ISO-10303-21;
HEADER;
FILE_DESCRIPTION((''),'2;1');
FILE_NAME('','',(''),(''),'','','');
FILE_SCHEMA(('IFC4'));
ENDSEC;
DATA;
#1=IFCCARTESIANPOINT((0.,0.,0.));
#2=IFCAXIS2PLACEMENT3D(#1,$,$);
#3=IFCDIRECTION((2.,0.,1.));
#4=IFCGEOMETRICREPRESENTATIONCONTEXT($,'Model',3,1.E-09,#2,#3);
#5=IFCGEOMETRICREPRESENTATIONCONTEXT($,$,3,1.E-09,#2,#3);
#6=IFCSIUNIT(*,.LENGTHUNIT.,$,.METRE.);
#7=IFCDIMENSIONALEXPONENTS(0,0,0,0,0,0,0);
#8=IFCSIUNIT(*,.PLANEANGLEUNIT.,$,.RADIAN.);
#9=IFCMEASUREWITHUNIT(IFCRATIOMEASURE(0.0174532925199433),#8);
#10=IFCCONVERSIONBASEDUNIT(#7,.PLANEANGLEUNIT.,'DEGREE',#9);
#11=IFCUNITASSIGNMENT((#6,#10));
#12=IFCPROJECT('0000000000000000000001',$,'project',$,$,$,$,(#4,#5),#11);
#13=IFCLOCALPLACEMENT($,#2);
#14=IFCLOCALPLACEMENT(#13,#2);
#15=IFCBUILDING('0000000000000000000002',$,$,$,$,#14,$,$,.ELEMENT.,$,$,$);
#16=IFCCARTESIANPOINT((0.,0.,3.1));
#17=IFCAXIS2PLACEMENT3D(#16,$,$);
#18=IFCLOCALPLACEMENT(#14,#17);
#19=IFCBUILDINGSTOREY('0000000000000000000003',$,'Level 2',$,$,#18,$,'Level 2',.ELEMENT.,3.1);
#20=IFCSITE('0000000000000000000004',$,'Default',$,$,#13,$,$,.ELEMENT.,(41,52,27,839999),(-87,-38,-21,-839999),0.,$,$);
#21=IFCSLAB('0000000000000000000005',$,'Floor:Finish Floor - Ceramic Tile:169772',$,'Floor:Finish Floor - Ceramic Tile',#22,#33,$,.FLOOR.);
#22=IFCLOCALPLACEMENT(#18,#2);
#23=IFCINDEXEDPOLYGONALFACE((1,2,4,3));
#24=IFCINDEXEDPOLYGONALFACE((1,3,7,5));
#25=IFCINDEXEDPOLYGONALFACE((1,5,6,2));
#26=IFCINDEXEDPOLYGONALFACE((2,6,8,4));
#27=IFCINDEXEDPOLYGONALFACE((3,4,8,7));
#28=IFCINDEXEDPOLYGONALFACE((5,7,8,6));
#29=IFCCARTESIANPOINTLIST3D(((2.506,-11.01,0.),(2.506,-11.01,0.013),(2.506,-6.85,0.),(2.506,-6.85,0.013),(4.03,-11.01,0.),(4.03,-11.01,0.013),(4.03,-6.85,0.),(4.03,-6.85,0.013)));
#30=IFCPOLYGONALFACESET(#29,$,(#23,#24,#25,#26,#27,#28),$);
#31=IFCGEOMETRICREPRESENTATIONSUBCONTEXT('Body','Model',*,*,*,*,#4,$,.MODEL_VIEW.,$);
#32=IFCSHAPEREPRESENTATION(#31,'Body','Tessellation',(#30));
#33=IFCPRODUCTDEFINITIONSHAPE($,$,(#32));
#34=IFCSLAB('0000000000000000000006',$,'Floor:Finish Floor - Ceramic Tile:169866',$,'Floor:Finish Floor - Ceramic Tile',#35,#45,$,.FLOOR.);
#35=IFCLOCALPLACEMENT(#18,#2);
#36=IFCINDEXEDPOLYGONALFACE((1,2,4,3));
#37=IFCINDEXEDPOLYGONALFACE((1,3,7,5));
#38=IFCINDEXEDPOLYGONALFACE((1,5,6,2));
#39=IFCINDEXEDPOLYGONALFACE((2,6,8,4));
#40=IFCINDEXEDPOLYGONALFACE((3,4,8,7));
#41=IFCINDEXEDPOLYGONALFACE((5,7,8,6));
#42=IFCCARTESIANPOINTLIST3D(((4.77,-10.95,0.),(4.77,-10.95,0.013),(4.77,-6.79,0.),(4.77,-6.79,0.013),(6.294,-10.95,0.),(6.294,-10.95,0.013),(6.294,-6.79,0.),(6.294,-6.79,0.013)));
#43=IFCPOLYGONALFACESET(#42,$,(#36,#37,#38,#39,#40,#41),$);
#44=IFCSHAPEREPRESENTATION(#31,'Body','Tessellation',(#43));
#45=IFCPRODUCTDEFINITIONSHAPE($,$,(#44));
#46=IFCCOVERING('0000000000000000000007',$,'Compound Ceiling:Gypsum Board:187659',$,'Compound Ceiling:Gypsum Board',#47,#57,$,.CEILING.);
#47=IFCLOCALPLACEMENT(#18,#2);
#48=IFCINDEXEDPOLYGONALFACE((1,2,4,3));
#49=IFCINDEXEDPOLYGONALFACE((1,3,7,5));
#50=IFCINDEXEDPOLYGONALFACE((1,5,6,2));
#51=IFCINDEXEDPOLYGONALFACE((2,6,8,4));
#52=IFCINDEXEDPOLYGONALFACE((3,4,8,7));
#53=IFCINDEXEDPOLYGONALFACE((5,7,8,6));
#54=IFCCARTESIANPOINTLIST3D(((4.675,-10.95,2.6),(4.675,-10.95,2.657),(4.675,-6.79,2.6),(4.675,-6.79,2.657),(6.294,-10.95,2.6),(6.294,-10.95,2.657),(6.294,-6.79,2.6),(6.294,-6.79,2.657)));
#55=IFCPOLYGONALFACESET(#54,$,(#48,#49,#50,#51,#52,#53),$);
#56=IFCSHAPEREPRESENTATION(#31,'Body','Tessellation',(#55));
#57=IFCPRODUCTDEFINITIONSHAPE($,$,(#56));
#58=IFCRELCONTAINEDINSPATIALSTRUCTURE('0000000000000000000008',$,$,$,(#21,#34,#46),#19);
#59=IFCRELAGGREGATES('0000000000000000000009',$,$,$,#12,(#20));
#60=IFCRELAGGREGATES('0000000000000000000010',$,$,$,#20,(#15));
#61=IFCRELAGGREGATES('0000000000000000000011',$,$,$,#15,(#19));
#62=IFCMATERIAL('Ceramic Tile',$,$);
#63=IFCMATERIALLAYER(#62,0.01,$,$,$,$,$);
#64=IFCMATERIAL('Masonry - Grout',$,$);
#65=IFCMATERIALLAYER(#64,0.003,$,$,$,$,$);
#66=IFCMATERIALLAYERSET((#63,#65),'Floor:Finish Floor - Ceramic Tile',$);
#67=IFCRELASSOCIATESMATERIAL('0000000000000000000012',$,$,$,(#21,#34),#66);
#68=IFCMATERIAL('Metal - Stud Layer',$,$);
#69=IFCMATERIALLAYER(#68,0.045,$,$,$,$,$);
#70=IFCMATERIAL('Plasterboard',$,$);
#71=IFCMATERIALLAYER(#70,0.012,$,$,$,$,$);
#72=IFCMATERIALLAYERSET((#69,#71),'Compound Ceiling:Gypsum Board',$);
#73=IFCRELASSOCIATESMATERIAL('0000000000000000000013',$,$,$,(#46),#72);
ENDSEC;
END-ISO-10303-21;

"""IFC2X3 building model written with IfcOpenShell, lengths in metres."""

from ifc_helpers import new_model, entity, si_unit, converted_unit, direction, frame, frame_2d, origin, place, context, subcontext, project, spatial, rectangle, extrude, material, layer, layer_set, layer_usage, element, save


model = new_model("IFC2X3")

# Units and contexts
model_context = context("Model", 3, precision=1e-09, world=origin(), true_north=direction((2.0, 0.0, 1.0)))
context_of_model = context(None, 3, precision=1e-09, world=origin(), true_north=direction((2.0, 0.0, 1.0)))
body_context = subcontext(model_context, "Body", "Model", "MODEL_VIEW")
ifc_project = project(units=[si_unit("LENGTHUNIT", "METRE"), converted_unit("PLANEANGLEUNIT", "DEGREE", entity("IfcRatioMeasure", 0.0174532925199433), si_unit("PLANEANGLEUNIT", "RADIAN"), dimensions=[0, 0, 0, 0, 0, 0, 0])], contexts=[model_context, context_of_model])

# Site, building, storey
site_placement = place(None, origin())
site = spatial("IfcSite", under=ifc_project, at=site_placement, Name="Default", CompositionType="ELEMENT", RefLatitude=(41, 52, 27, 839999), RefLongitude=(-87, -38, -21, -839999), RefElevation=0.0)
building_placement = place(site_placement, origin())
building = spatial("IfcBuilding", under=site, at=building_placement, CompositionType="ELEMENT")
storey_placement = place(building_placement, frame((0.0, 0.0, 3.1)))
storey = spatial("IfcBuildingStorey", under=building, at=storey_placement, Name="Level 2", LongName="Level 2", CompositionType="ELEMENT", Elevation=3.1)

# Slabs
ifc_material_1 = material(Name="Ceramic Tile")
ifc_layer_1 = layer(ifc_material_1, 0.01)
ifc_material_2 = material(Name="Masonry - Grout")
ifc_layer_2 = layer(ifc_material_2, 0.003)
ifc_layer_set_1 = layer_set([ifc_layer_1, ifc_layer_2], Name="Floor:Finish Floor - Ceramic Tile")
ifc_layer_usage_1 = layer_usage(ifc_layer_set_1, "AXIS3", "POSITIVE", 0.0)
slab_1_placement = place(storey_placement, origin())
element("IfcSlab", 1, at=slab_1_placement, inside=storey, material=ifc_layer_usage_1, Name="Floor:Finish Floor - Ceramic Tile:169772", ObjectType="Floor:Finish Floor - Ceramic Tile", PredefinedType="FLOOR", context=body_context, shape_type="SweptSolid", body=[
    extrude(rectangle(XDim=4.16, YDim=1.524, at=frame_2d((0.0, 0.0), x_axis=(1.0, 0.0))), frame((3.268, -8.93, 0.013), z_axis=(0.0, 0.0, -1.0), x_axis=(0.0, 1.0, 0.0)), (0.0, 0.0, 1.0), 0.013),
])
ifc_layer_usage_2 = layer_usage(ifc_layer_set_1, "AXIS3", "POSITIVE", 0.0)
slab_2_placement = place(storey_placement, origin())
element("IfcSlab", 2, at=slab_2_placement, inside=storey, material=ifc_layer_usage_2, Name="Floor:Finish Floor - Ceramic Tile:169866", ObjectType="Floor:Finish Floor - Ceramic Tile", PredefinedType="FLOOR", context=body_context, shape_type="SweptSolid", body=[
    extrude(rectangle(XDim=4.16, YDim=1.524, at=frame_2d((0.0, 0.0), x_axis=(1.0, 0.0))), frame((5.532, -8.87, 0.013), z_axis=(0.0, 0.0, -1.0), x_axis=(0.0, 1.0, 0.0)), (0.0, 0.0, 1.0), 0.013),
])

# Shared definitions
ifc_material_3 = material(Name="Metal - Stud Layer")
ifc_material_4 = material(Name="Plasterboard")

# Shared definitions
ifc_layer_3 = layer(ifc_material_3, 0.045)
ifc_layer_4 = layer(ifc_material_4, 0.012)
ifc_layer_set_2 = layer_set([ifc_layer_3, ifc_layer_4], Name="Compound Ceiling:Gypsum Board")

# Covering
ifc_layer_usage_3 = layer_usage(ifc_layer_set_2, "AXIS3", "NEGATIVE", 0.0)
covering_1_placement = place(storey_placement, origin())
element("IfcCovering", 3, at=covering_1_placement, inside=storey, material=ifc_layer_usage_3, Name="Compound Ceiling:Gypsum Board:187659", ObjectType="Compound Ceiling:Gypsum Board", PredefinedType="CEILING", context=body_context, shape_type="SweptSolid", body=[
    extrude(rectangle(XDim=1.619, YDim=4.16, at=frame_2d((0.0, 0.0), x_axis=(1.0, 0.0))), frame((5.4845, -8.87, 2.6)), (0.0, 0.0, 1.0), 0.057),
])

save(model, "model.ifc")
